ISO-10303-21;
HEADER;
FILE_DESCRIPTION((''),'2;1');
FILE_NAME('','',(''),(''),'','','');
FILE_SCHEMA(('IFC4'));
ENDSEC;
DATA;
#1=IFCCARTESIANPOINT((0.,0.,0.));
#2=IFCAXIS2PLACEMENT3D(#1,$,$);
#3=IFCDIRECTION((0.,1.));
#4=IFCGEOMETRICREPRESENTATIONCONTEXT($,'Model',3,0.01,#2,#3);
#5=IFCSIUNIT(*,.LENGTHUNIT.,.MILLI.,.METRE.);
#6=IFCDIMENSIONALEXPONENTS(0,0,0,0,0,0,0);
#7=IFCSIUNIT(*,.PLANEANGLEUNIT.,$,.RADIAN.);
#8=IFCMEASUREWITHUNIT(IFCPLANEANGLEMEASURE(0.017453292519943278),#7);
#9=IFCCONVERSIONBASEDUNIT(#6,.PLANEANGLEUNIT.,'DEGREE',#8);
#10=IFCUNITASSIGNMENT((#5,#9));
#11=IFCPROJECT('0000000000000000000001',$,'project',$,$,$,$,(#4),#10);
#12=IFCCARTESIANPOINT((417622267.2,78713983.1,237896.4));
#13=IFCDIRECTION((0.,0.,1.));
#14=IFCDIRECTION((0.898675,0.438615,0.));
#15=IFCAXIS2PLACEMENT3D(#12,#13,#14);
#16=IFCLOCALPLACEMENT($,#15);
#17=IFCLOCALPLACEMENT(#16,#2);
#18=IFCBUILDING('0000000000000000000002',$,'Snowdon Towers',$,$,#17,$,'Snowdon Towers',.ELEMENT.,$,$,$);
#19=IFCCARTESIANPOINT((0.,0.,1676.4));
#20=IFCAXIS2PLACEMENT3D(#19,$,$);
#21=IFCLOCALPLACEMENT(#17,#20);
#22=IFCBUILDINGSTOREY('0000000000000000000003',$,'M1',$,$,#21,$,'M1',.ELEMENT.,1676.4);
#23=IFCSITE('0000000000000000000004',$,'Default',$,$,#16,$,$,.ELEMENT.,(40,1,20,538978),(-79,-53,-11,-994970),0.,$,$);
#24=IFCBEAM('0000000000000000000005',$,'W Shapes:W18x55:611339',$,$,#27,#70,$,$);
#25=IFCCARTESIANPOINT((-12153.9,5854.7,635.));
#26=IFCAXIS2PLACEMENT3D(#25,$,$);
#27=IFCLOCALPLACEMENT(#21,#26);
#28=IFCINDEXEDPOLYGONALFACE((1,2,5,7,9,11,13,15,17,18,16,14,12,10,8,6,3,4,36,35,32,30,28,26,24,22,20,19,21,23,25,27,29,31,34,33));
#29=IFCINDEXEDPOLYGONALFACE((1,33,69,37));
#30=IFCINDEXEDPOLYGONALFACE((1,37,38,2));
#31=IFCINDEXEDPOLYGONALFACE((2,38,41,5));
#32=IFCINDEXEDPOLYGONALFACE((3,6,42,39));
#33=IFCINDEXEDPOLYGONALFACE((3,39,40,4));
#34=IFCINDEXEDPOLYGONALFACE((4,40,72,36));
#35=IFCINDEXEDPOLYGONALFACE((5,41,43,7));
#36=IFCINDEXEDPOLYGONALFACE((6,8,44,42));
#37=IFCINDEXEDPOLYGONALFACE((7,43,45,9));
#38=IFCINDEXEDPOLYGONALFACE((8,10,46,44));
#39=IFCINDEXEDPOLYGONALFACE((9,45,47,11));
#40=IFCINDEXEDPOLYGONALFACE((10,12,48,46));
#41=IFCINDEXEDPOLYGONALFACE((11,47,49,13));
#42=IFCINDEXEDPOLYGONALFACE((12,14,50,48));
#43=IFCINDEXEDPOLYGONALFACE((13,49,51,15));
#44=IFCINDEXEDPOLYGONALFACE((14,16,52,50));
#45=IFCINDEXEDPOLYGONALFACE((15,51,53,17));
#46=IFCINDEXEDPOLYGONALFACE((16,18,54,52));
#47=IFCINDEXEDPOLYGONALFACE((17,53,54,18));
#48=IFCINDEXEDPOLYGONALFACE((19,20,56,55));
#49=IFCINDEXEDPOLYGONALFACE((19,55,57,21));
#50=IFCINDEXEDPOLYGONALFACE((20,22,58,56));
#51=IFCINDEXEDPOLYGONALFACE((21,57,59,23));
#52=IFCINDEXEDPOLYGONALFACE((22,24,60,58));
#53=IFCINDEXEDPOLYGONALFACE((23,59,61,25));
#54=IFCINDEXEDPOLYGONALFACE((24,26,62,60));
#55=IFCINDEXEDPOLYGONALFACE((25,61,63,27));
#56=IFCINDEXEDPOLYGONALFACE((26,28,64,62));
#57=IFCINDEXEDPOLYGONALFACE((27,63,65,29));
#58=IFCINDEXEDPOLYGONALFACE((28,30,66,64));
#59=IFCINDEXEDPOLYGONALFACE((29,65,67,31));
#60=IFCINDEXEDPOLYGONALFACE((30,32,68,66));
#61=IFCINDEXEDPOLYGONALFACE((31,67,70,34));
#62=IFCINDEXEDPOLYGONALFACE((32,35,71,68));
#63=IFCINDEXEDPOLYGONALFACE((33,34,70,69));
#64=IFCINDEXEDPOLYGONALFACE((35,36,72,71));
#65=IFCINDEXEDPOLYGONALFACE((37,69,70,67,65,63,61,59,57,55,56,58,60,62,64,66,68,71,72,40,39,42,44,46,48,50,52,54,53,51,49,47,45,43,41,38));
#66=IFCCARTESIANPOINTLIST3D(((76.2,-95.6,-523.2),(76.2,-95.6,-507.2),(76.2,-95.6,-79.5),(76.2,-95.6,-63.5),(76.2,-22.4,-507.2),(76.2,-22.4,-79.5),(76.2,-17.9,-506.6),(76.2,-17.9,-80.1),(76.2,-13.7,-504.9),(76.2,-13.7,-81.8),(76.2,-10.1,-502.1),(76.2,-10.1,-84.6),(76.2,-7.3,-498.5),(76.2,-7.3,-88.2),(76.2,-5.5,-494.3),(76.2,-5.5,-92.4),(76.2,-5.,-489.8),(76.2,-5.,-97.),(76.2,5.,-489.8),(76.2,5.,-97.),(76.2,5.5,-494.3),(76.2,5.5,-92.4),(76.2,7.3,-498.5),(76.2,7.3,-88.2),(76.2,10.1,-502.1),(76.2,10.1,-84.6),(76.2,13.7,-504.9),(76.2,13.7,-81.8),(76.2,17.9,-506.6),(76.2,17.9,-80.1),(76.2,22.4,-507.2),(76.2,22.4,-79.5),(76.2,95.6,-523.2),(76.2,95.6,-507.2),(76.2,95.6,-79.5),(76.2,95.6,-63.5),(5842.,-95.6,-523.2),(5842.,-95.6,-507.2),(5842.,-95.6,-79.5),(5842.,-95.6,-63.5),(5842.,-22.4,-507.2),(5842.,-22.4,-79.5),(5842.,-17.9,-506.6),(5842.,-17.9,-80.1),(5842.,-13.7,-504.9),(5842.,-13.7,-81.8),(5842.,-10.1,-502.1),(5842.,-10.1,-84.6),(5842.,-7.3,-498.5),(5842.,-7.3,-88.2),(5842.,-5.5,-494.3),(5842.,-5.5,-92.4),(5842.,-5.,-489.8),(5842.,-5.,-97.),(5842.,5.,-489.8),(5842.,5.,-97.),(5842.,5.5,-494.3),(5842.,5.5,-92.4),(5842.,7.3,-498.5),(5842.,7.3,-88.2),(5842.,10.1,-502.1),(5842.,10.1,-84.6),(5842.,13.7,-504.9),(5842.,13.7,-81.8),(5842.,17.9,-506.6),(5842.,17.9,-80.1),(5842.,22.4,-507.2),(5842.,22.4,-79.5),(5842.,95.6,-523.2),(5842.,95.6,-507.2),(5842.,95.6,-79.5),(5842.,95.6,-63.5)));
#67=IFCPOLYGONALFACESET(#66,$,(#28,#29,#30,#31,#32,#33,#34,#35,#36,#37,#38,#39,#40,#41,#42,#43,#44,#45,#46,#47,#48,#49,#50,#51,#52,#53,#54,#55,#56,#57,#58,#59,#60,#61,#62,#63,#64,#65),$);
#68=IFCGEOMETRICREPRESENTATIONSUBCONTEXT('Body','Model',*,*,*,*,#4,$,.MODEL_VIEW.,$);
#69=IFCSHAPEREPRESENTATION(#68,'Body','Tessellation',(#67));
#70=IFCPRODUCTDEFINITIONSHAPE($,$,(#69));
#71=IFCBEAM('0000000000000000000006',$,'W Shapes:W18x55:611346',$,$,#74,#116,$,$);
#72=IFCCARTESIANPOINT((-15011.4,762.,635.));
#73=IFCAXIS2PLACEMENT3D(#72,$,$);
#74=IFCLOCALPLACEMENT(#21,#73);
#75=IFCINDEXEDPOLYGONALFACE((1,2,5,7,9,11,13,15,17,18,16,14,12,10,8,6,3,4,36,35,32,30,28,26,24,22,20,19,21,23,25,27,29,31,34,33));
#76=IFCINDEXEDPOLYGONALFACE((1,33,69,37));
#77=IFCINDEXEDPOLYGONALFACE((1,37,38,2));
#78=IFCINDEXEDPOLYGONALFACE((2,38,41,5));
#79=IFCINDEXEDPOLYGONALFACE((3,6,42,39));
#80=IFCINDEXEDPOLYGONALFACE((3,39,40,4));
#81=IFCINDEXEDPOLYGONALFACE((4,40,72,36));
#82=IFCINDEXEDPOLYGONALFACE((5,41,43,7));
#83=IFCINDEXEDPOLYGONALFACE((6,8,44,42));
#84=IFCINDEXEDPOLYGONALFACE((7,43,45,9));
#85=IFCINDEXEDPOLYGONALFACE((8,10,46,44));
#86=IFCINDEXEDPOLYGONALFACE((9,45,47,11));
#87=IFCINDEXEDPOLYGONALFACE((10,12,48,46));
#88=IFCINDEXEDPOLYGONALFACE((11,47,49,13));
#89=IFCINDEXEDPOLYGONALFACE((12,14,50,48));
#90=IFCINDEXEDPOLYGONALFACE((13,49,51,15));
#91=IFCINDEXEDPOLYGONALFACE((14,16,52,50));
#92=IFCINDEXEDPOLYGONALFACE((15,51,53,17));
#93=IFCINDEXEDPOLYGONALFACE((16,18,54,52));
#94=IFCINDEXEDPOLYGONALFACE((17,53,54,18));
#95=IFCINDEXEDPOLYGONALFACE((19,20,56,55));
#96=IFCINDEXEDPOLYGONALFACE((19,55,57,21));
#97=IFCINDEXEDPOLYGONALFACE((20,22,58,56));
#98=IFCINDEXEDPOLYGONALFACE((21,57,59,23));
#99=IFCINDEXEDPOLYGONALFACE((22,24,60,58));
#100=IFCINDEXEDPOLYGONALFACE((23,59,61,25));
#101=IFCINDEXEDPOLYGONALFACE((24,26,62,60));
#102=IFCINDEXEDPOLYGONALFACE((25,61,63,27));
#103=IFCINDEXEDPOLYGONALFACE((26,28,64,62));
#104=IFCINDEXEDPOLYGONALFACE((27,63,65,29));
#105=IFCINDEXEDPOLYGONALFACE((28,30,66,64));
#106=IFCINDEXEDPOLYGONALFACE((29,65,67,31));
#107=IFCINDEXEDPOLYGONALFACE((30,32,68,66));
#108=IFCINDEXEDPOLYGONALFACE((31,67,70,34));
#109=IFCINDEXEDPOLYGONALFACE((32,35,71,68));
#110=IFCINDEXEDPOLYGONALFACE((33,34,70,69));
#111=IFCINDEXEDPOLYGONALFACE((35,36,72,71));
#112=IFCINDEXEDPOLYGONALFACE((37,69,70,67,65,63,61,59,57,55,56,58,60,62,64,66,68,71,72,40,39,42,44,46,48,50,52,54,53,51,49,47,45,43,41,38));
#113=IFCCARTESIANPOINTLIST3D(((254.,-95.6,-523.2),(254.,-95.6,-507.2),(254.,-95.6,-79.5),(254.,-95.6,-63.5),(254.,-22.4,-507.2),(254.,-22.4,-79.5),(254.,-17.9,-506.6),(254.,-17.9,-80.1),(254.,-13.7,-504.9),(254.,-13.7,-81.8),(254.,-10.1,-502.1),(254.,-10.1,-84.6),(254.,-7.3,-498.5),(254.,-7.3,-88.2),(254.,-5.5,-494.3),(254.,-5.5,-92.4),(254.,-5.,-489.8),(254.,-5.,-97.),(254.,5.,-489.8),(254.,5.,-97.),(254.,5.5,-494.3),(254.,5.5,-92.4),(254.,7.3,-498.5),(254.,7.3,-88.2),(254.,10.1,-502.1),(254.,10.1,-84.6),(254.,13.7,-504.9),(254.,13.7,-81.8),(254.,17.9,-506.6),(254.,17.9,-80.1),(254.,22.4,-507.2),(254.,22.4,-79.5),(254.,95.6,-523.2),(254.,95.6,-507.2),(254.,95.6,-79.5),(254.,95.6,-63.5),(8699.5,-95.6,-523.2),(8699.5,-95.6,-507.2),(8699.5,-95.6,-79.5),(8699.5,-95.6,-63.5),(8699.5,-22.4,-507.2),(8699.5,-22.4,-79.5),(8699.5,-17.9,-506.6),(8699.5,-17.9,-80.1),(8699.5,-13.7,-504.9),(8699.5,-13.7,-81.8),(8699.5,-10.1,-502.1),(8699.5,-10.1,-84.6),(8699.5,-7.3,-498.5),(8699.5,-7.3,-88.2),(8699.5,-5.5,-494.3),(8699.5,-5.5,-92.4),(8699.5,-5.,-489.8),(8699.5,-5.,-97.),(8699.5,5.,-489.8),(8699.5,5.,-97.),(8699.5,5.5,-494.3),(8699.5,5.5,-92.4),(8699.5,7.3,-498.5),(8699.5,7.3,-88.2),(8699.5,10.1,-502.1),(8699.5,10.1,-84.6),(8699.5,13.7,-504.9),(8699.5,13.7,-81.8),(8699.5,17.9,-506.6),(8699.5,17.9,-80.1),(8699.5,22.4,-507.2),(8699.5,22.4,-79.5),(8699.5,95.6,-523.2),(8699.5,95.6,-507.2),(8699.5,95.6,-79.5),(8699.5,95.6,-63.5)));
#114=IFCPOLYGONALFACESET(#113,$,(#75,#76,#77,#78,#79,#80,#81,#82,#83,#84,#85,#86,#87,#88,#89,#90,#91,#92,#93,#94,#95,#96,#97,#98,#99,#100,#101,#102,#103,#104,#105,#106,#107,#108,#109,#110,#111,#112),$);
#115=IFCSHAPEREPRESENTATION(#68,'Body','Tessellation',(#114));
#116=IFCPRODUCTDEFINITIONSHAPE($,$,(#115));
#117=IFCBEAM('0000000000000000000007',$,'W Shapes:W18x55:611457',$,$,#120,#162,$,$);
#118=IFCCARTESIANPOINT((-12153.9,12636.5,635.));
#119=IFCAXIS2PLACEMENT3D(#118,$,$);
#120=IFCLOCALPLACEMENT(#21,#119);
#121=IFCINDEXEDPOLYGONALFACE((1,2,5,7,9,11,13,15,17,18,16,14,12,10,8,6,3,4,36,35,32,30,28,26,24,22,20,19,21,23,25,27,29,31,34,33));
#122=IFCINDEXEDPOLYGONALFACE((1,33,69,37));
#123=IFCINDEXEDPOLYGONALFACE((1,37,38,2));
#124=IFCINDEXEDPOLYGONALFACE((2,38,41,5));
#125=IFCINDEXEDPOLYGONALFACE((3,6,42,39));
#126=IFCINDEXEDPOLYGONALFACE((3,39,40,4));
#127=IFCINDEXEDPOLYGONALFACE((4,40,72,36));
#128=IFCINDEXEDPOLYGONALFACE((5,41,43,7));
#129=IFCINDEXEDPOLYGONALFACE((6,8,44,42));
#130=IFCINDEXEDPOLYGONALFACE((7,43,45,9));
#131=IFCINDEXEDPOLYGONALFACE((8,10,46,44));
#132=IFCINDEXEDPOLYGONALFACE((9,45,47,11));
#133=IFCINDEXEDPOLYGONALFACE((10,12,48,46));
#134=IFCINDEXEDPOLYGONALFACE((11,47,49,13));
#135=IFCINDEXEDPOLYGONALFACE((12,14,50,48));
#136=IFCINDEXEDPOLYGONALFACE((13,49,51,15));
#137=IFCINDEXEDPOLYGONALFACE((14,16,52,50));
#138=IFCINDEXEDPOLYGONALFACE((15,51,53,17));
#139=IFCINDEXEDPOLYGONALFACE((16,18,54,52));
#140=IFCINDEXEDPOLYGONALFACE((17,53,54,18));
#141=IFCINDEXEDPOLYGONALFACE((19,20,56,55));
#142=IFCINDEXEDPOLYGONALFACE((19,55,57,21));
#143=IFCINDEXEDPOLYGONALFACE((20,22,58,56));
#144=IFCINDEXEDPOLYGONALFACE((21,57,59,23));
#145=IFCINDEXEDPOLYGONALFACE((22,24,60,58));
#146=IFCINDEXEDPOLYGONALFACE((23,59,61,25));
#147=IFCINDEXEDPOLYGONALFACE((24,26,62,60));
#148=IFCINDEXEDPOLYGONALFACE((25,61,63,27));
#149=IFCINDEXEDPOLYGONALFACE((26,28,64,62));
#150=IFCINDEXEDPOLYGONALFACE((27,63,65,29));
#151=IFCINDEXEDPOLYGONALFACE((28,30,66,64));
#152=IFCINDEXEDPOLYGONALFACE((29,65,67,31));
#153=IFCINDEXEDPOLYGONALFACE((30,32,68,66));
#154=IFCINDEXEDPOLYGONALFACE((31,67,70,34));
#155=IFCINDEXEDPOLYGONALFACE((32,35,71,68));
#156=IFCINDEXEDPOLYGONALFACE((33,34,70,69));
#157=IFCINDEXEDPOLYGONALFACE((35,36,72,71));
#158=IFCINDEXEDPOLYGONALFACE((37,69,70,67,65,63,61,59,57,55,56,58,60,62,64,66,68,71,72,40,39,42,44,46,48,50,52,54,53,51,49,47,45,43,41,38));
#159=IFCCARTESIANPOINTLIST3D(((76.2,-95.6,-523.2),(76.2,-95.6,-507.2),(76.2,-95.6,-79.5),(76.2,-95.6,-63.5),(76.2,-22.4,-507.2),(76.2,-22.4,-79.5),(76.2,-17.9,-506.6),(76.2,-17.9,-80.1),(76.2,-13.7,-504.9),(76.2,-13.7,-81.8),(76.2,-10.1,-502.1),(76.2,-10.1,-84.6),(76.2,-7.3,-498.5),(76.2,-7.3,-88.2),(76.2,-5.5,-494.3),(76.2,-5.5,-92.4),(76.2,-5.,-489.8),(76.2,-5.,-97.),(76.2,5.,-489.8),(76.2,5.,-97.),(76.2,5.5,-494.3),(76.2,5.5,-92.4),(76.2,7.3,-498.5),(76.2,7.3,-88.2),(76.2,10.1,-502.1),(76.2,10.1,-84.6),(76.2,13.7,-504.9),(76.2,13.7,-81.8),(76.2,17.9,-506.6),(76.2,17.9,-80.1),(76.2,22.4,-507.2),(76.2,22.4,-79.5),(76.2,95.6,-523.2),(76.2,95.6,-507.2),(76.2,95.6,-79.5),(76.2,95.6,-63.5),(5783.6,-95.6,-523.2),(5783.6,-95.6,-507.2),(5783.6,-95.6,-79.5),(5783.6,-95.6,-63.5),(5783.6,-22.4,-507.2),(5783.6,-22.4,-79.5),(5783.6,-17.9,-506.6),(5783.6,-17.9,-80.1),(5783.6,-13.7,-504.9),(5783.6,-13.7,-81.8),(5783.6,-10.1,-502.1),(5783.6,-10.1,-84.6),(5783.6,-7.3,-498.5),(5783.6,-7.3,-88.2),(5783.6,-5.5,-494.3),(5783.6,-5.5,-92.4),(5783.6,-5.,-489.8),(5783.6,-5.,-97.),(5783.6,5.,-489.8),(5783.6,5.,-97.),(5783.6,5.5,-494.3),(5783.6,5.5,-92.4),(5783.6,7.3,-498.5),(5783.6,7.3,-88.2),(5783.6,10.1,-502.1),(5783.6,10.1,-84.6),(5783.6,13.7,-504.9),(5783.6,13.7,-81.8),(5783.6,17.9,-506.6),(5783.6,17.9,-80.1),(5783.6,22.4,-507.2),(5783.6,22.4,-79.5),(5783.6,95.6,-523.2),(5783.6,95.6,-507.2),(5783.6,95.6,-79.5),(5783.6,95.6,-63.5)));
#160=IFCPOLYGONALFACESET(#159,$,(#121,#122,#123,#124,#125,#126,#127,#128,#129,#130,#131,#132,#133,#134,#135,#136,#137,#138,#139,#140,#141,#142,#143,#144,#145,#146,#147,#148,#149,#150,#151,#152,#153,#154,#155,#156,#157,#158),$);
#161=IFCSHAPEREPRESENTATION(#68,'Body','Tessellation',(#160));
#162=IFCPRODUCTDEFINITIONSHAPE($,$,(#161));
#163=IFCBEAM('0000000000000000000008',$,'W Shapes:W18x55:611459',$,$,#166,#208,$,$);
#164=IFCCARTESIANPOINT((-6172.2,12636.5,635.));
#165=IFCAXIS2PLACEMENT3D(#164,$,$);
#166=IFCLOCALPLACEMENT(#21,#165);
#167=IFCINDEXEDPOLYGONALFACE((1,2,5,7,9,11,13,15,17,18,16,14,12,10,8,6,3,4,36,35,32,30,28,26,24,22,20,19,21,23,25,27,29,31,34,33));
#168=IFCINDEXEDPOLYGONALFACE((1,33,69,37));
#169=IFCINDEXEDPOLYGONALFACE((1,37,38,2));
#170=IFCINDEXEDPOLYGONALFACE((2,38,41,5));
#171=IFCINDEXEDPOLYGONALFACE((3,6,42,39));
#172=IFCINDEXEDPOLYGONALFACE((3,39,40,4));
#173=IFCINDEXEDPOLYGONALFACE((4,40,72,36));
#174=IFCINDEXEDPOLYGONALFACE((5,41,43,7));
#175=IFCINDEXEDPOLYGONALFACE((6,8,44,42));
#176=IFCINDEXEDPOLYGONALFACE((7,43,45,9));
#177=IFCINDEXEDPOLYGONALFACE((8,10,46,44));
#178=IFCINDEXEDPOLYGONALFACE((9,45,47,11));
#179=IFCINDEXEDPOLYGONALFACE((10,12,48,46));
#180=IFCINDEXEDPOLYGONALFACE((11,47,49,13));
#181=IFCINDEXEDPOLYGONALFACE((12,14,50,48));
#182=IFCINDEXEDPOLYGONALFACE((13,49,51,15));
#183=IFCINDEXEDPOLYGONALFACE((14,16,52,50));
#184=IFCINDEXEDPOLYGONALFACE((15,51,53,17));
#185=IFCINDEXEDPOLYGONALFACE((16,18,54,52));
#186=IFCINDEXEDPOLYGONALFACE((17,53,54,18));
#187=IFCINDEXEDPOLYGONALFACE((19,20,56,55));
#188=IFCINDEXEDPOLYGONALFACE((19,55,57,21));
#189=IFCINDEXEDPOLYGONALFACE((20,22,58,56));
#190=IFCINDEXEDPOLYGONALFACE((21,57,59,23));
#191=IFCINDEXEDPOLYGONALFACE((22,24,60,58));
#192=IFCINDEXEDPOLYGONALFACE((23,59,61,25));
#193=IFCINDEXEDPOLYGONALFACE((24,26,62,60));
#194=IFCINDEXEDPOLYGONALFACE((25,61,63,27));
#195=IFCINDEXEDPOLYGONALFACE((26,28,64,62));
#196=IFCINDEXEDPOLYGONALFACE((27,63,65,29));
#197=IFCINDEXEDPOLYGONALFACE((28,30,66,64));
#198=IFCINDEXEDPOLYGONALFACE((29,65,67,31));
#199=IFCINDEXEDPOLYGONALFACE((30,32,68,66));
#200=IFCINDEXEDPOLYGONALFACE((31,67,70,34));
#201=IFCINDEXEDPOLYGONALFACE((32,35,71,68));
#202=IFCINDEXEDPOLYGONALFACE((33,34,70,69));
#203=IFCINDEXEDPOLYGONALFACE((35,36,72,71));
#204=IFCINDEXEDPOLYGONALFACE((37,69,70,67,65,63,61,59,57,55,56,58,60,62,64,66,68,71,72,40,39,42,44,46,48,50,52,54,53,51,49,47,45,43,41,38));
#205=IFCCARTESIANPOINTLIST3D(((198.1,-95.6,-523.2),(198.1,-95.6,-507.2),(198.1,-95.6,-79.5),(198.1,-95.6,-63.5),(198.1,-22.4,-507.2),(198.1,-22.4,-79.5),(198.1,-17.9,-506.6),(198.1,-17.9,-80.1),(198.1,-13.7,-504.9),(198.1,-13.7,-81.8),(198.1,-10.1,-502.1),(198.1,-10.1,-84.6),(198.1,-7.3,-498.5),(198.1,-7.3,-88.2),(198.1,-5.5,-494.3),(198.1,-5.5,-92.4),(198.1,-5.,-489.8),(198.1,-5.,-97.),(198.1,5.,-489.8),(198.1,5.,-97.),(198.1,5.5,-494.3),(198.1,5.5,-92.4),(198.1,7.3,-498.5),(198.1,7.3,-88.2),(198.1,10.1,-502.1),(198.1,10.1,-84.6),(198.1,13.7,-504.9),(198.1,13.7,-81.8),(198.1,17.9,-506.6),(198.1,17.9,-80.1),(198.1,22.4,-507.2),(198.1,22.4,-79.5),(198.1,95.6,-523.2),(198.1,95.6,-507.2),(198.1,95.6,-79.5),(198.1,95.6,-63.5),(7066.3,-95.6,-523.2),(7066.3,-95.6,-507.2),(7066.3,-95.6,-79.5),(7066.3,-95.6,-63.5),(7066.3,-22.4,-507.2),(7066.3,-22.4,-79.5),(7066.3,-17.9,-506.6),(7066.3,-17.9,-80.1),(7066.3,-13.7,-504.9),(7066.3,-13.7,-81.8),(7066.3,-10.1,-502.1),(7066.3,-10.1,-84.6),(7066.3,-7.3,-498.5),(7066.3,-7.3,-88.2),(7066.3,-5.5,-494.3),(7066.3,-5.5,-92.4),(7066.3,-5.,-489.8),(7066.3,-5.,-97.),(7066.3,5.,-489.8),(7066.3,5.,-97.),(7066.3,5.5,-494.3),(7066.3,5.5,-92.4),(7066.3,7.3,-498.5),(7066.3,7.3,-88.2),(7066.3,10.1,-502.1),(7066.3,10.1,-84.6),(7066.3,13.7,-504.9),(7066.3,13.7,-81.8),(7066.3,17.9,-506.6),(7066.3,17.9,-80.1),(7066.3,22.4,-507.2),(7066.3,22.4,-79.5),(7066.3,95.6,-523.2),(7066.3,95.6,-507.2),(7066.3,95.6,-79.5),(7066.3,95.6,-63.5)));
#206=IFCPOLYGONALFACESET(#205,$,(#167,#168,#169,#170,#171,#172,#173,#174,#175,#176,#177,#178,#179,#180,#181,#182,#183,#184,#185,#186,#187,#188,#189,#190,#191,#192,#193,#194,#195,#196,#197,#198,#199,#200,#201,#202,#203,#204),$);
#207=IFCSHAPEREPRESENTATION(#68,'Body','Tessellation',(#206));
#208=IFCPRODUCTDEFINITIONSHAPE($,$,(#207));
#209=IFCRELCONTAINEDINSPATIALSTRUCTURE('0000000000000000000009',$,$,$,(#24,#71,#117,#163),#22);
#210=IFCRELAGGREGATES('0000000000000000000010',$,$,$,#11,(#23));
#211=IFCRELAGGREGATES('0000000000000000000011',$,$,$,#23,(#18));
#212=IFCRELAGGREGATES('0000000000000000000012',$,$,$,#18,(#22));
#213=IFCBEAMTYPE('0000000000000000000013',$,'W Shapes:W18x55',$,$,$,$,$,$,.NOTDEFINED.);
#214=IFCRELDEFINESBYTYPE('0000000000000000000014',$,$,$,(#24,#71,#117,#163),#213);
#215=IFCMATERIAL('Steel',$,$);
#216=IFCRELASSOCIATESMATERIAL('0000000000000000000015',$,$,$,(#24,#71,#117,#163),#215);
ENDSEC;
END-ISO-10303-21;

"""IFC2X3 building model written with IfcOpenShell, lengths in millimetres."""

from ifc_helpers import new_model, entity, si_unit, converted_unit, direction, frame, frame_2d, origin, place, context, subcontext, project, spatial, i_section, extrude, material, type_object, element, save


model = new_model("IFC2X3")

# Units and contexts
model_context = context("Model", 3, precision=0.01, world=origin(), true_north=direction((0.0, 1.0)))
body_context = subcontext(model_context, "Body", "Model", "MODEL_VIEW")
ifc_project = project(units=[si_unit("LENGTHUNIT", "METRE", prefix="MILLI"), converted_unit("PLANEANGLEUNIT", "DEGREE", entity("IfcPlaneAngleMeasure", 0.017453292519943278), si_unit("PLANEANGLEUNIT", "RADIAN"), dimensions=[0, 0, 0, 0, 0, 0, 0])], contexts=[model_context])

# Site, building, storey
site_placement = place(None, frame((417622267.2, 78713983.1, 237896.4), z_axis=(0.0, 0.0, 1.0), x_axis=(0.898675, 0.438615, 0.0)))
site = spatial("IfcSite", under=ifc_project, at=site_placement, Name="Default", CompositionType="ELEMENT", RefLatitude=(40, 1, 20, 538978), RefLongitude=(-79, -53, -11, -994970), RefElevation=0.0)
building_placement = place(site_placement, origin())
building = spatial("IfcBuilding", under=site, at=building_placement, Name="Snowdon Towers", LongName="Snowdon Towers", CompositionType="ELEMENT")
storey_placement = place(building_placement, frame((0.0, 0.0, 1676.4)))
storey = spatial("IfcBuildingStorey", under=building, at=storey_placement, Name="M1", LongName="M1", CompositionType="ELEMENT", Elevation=1676.4)

# Shared definitions
ifc_material_1 = material(Name="Steel")

# Beams
beam_type_1 = type_object("IfcBeamType", Name="W Shapes:W18x55", PredefinedType="NOTDEFINED")
beam_1_placement = place(storey_placement, frame((-12153.9, 5854.7, 635.0)))
element("IfcBeam", 1, at=beam_1_placement, inside=storey, type_object=beam_type_1, material=ifc_material_1, Name="W Shapes:W18x55:611339", context=body_context, shape_type="SweptSolid", body=[
    extrude(i_section(OverallWidth=191.3, OverallDepth=459.7, WebThickness=9.9, FlangeThickness=16.0, FilletRadius=17.5, at=frame_2d((0.0, 0.0), x_axis=(0.0, 1.0))), frame((76.2, 0.0, -293.4), z_axis=(1.0, 0.0, 0.0), x_axis=(0.0, 0.0, -1.0)), (0.0, 0.0, 1.0), 5765.8),
])
beam_2_placement = place(storey_placement, frame((-15011.4, 762.0, 635.0)))
element("IfcBeam", 2, at=beam_2_placement, inside=storey, type_object=beam_type_1, material=ifc_material_1, Name="W Shapes:W18x55:611346", context=body_context, shape_type="SweptSolid", body=[
    extrude(i_section(OverallWidth=191.3, OverallDepth=459.7, WebThickness=9.9, FlangeThickness=16.0, FilletRadius=17.5, at=frame_2d((0.0, 0.0), x_axis=(0.0, 1.0))), frame((254.0, 0.0, -293.4), z_axis=(1.0, 0.0, 0.0), x_axis=(0.0, 0.0, -1.0)), (0.0, 0.0, 1.0), 8445.5),
])
beam_3_placement = place(storey_placement, frame((-12153.9, 12636.5, 635.0)))
element("IfcBeam", 3, at=beam_3_placement, inside=storey, type_object=beam_type_1, material=ifc_material_1, Name="W Shapes:W18x55:611457", context=body_context, shape_type="SweptSolid", body=[
    extrude(i_section(OverallWidth=191.3, OverallDepth=459.7, WebThickness=9.9, FlangeThickness=16.0, FilletRadius=17.5, at=frame_2d((0.0, 0.0), x_axis=(0.0, 1.0))), frame((76.2, 0.0, -293.4), z_axis=(1.0, 0.0, 0.0), x_axis=(0.0, 0.0, -1.0)), (0.0, 0.0, 1.0), 5707.4),
])
beam_4_placement = place(storey_placement, frame((-6172.2, 12636.5, 635.0)))
element("IfcBeam", 4, at=beam_4_placement, inside=storey, type_object=beam_type_1, material=ifc_material_1, Name="W Shapes:W18x55:611459", context=body_context, shape_type="SweptSolid", body=[
    extrude(i_section(OverallWidth=191.3, OverallDepth=459.7, WebThickness=9.9, FlangeThickness=16.0, FilletRadius=17.5, at=frame_2d((0.0, 0.0), x_axis=(0.0, 1.0))), frame((198.1, 0.0, -293.4), z_axis=(1.0, 0.0, 0.0), x_axis=(0.0, 0.0, -1.0)), (0.0, 0.0, 1.0), 6868.2),
])

save(model, "model.ifc")
